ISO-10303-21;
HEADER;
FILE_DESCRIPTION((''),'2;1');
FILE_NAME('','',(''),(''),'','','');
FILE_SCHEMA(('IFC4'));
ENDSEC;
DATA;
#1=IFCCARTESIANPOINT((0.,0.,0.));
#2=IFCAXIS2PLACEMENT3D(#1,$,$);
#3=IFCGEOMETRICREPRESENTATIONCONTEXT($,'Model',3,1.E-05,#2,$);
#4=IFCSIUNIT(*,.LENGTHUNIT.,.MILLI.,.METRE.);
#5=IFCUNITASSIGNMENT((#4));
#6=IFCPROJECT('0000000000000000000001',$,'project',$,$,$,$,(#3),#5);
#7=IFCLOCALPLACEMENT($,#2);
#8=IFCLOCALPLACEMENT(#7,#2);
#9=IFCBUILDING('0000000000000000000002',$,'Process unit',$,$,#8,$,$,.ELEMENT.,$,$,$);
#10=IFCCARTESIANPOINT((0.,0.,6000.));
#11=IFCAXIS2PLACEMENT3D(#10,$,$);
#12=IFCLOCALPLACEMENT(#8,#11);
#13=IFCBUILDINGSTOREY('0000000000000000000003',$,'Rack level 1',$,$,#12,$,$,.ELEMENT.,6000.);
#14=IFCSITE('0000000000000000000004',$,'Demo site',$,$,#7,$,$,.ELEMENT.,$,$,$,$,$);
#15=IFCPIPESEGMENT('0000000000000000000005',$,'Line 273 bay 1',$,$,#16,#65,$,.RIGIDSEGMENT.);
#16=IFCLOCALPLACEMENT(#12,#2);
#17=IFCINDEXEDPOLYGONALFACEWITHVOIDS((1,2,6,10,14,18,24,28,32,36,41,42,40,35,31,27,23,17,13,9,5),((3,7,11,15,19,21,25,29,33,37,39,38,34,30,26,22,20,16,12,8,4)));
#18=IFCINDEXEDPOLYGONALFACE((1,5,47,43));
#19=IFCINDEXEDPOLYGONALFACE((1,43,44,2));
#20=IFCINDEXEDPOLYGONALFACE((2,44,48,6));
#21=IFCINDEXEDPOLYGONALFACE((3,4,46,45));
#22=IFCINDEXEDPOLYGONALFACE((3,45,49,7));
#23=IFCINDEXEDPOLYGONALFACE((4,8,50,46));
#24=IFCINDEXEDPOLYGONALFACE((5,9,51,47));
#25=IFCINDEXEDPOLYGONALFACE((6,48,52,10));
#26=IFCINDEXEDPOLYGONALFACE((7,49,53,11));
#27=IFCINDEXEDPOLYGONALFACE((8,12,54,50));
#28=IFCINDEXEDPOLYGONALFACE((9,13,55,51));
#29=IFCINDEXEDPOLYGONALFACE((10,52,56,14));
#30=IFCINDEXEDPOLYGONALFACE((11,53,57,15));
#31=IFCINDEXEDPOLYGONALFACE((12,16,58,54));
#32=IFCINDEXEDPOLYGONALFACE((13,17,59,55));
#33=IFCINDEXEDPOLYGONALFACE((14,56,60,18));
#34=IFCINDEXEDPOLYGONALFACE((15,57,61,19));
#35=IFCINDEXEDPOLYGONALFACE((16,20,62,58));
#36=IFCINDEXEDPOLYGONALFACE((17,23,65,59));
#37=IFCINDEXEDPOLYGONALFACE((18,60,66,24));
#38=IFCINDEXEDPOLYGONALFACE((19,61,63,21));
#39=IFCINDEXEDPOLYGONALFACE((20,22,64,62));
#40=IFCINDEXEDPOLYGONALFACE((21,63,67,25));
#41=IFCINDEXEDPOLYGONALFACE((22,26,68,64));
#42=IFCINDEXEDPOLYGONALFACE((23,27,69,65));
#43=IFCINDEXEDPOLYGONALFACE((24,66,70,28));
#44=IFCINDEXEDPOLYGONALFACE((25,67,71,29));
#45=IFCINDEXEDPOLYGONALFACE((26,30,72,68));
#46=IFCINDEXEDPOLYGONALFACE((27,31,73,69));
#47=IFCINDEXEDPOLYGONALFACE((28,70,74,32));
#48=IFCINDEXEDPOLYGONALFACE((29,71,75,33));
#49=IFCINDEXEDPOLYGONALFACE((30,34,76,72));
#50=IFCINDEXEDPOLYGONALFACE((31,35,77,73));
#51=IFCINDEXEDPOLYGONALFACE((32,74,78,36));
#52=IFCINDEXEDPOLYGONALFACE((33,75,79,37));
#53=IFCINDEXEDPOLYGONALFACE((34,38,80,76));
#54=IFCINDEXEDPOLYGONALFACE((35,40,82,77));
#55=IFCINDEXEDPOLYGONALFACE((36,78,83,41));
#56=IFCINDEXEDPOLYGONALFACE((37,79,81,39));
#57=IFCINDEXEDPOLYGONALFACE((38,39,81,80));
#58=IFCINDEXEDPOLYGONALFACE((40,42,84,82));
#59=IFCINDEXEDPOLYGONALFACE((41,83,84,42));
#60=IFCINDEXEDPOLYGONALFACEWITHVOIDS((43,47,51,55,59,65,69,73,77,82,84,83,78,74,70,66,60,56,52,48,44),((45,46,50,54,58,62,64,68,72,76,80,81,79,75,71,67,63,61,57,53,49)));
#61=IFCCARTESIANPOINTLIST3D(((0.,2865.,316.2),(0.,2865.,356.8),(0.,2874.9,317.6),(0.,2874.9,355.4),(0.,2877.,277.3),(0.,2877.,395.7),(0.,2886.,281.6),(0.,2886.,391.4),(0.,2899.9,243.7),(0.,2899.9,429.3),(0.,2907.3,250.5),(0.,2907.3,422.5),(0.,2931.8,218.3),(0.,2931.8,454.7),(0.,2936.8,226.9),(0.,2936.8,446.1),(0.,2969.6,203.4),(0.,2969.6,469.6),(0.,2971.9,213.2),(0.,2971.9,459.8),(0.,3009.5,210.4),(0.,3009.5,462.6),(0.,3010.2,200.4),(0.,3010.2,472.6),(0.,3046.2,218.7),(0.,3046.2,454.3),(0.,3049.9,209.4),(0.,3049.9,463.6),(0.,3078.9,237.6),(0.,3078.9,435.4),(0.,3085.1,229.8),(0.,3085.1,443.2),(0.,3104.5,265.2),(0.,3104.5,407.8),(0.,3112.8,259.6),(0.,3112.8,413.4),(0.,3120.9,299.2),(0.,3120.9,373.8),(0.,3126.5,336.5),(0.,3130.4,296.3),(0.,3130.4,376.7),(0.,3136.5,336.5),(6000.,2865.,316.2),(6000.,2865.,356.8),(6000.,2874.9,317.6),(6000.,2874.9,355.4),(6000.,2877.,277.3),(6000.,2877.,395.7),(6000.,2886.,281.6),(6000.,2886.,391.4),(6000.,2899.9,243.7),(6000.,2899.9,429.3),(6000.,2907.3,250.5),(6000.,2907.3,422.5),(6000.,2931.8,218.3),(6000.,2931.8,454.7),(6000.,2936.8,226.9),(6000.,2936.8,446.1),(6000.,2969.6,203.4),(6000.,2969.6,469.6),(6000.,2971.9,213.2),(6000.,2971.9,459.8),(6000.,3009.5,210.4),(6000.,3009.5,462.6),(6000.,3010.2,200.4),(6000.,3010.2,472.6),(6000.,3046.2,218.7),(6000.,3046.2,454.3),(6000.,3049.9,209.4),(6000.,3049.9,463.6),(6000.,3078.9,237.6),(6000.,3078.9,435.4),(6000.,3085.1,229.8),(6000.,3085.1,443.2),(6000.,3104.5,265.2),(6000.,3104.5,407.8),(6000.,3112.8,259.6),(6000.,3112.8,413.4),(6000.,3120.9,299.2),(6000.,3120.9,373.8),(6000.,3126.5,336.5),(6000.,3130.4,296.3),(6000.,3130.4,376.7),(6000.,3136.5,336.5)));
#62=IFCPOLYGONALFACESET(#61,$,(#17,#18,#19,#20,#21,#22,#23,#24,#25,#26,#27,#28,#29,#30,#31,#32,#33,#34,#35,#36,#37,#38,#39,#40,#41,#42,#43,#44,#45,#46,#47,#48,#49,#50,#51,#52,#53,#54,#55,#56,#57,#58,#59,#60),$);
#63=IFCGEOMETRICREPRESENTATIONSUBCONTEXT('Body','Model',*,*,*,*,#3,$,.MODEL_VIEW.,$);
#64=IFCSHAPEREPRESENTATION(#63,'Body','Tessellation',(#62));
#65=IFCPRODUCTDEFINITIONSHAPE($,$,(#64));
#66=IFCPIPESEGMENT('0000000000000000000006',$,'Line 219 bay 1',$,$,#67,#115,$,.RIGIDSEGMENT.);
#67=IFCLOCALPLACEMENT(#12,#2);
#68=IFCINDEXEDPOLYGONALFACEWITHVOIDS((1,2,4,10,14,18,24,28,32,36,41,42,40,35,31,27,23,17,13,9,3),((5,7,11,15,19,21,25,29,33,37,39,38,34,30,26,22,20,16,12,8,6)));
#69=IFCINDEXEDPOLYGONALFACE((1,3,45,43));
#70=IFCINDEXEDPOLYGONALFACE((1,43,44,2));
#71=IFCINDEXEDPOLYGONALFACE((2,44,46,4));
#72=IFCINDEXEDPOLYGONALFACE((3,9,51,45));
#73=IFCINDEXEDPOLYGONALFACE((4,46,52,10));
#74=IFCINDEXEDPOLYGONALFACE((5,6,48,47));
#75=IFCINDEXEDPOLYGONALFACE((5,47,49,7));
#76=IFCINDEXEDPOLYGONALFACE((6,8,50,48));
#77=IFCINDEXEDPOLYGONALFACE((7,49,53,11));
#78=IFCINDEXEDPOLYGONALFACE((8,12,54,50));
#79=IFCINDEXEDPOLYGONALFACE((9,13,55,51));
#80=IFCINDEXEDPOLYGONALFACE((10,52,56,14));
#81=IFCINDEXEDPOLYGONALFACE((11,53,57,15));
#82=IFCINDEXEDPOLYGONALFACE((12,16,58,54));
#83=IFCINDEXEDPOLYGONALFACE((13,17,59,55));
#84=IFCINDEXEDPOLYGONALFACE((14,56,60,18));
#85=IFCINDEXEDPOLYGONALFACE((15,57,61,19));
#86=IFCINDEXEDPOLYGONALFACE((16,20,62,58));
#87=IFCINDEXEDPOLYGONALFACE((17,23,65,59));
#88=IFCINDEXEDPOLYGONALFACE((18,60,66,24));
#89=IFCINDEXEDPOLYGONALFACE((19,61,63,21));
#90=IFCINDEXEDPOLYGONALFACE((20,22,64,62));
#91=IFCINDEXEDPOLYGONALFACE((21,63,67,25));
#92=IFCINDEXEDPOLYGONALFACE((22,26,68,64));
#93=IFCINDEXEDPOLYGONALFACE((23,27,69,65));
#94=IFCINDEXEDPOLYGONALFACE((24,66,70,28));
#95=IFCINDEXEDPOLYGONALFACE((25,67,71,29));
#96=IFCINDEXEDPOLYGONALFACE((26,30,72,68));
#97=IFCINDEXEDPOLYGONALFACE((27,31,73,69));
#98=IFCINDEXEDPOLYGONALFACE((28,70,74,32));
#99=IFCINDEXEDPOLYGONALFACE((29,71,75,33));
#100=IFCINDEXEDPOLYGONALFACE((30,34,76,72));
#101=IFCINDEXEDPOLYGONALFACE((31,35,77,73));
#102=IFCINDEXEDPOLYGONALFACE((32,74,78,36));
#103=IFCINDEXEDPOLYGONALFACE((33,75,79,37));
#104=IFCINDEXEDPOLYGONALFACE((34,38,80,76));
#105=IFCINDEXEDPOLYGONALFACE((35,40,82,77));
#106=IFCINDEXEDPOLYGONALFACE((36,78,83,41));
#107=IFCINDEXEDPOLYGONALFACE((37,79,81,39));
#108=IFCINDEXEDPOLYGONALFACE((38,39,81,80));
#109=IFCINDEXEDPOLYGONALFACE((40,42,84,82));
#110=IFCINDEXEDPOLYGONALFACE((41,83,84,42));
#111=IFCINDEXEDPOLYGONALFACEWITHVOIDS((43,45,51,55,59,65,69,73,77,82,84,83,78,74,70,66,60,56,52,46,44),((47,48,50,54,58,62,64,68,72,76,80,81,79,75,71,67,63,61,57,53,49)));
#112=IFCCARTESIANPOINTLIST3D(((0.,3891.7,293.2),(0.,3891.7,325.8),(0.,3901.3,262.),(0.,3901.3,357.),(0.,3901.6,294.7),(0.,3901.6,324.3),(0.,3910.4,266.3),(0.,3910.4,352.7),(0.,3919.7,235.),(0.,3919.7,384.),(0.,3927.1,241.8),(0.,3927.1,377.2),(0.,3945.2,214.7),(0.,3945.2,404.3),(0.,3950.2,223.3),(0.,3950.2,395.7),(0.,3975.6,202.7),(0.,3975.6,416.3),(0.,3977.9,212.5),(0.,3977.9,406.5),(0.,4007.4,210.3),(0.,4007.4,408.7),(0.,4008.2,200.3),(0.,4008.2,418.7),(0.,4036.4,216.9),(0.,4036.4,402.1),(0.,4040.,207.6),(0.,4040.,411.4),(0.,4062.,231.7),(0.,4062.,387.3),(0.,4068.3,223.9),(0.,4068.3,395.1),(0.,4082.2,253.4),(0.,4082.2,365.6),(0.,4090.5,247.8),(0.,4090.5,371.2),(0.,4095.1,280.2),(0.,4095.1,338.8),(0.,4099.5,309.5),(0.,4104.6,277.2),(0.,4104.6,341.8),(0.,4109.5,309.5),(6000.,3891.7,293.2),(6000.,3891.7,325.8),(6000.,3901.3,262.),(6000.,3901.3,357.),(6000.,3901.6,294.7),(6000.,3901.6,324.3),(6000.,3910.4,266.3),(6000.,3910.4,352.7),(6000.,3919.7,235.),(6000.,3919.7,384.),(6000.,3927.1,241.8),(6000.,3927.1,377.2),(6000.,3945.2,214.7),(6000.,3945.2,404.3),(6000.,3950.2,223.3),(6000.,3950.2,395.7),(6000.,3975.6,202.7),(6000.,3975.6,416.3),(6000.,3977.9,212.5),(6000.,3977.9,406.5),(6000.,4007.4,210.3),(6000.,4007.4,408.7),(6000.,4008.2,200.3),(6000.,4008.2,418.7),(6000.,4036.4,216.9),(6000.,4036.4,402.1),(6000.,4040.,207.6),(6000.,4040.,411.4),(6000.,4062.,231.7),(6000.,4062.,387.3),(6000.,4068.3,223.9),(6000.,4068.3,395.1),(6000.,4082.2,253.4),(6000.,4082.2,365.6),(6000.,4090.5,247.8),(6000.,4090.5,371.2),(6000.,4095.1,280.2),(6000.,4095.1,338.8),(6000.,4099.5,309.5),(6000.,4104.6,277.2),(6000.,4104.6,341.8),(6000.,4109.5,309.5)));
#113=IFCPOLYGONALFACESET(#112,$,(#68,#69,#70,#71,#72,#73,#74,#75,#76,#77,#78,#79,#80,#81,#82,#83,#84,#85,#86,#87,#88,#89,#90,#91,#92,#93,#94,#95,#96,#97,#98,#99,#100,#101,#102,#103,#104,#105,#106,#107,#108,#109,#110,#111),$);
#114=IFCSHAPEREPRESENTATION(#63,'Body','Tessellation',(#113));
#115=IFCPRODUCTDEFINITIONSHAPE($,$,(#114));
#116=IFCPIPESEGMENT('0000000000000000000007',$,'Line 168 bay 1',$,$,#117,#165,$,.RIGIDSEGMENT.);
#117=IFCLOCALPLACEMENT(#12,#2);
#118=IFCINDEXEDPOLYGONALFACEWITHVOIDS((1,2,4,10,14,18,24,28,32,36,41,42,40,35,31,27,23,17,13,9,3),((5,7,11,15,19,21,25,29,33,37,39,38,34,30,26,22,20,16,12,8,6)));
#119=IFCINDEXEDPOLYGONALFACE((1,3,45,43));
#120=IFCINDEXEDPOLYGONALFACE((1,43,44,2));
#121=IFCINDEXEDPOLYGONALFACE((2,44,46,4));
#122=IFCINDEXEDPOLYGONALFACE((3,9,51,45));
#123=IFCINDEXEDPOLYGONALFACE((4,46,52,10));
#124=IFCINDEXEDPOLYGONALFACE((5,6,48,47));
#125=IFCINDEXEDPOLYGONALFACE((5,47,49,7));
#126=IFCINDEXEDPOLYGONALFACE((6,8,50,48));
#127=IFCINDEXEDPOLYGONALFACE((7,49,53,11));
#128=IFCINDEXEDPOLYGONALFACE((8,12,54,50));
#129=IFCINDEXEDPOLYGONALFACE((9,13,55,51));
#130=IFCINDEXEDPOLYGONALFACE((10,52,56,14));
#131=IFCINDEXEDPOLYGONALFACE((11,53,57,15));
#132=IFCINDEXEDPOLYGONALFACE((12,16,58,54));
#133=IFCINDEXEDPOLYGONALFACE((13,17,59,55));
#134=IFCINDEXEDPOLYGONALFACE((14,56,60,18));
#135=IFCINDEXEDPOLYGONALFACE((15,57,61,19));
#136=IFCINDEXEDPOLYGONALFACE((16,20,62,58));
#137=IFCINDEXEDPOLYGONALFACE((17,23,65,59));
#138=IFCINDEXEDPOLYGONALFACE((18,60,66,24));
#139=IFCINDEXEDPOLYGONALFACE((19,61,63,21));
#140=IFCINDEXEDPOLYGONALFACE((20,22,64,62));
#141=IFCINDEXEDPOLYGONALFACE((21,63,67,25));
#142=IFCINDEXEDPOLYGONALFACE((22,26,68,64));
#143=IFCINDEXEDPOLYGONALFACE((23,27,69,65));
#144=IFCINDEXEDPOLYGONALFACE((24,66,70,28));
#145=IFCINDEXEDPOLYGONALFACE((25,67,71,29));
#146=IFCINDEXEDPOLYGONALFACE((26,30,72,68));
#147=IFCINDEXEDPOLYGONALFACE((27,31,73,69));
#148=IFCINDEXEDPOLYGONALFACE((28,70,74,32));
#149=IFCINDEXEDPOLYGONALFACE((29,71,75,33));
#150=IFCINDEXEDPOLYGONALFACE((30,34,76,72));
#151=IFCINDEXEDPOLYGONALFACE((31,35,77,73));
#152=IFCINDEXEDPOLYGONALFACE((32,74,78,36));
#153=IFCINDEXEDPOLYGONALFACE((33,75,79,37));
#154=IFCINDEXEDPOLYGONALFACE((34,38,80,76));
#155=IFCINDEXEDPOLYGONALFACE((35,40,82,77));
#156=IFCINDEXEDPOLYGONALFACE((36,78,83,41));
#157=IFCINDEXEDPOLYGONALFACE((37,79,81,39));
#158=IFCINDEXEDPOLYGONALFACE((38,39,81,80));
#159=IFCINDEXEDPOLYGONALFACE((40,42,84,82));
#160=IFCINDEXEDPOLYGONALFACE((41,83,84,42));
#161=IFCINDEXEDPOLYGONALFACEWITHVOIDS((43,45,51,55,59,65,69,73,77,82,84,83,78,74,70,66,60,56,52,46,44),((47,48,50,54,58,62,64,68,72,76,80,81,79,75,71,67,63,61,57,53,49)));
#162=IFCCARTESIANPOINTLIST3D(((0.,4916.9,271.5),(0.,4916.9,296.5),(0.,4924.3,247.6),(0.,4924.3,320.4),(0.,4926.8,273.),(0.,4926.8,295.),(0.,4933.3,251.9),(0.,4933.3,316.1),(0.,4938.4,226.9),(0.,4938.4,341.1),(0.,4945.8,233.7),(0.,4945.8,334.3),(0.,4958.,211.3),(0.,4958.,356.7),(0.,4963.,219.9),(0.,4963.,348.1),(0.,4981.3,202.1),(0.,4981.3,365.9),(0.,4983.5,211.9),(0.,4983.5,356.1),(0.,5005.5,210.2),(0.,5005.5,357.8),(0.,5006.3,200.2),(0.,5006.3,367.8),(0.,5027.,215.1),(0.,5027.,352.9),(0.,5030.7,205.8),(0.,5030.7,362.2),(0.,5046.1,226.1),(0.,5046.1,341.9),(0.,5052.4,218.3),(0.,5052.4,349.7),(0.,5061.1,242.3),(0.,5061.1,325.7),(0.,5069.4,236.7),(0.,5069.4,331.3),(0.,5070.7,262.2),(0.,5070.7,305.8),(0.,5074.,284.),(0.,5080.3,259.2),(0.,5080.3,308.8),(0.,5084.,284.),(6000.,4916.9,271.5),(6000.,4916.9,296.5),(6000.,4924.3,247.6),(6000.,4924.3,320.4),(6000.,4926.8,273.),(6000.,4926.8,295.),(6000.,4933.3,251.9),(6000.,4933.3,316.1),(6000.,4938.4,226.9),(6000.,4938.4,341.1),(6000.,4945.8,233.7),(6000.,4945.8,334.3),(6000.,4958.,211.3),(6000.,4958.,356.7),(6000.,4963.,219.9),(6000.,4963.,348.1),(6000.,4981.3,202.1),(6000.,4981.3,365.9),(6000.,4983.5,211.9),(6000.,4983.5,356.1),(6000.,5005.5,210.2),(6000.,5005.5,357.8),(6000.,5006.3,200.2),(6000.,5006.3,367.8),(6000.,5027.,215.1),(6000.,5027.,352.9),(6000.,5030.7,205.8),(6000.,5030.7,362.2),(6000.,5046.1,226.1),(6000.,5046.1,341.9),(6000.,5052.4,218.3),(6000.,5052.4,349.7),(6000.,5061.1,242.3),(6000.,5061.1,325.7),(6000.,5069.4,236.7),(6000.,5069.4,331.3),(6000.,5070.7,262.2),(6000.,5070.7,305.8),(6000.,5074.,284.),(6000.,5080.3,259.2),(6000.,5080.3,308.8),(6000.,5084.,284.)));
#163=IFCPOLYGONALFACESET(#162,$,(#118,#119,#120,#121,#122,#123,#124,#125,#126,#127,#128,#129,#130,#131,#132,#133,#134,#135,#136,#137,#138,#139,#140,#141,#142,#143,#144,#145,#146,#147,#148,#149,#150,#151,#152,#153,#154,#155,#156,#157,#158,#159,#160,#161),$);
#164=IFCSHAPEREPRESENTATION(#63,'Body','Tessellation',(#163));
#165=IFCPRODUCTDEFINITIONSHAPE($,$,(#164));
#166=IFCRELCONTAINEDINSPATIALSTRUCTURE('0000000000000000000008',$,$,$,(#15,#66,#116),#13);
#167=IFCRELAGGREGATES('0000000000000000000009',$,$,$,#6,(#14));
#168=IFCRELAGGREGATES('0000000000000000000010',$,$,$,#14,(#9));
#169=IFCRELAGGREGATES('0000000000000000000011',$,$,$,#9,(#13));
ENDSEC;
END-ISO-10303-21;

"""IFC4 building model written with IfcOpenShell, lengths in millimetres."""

from ifc_helpers import new_model, si_unit, frame, origin, place, context, subcontext, project, spatial, hollow_circle, extrude, element, save


model = new_model("IFC4")

# Units and contexts
model_context = context("Model", 3, precision=1e-05, world=origin())
body_context = subcontext(model_context, "Body", "Model", "MODEL_VIEW")
ifc_project = project(units=[si_unit("LENGTHUNIT", "METRE", prefix="MILLI")], contexts=[model_context])

# Site, building, storey
site_placement = place(None, origin())
site = spatial("IfcSite", under=ifc_project, at=site_placement, Name="Demo site", CompositionType="ELEMENT")
building_placement = place(site_placement, origin())
building = spatial("IfcBuilding", under=site, at=building_placement, Name="Process unit", CompositionType="ELEMENT")
storey_placement = place(building_placement, frame((0.0, 0.0, 6000.0)))
storey = spatial("IfcBuildingStorey", under=building, at=storey_placement, Name="Rack level 1", CompositionType="ELEMENT", Elevation=6000.0)

# Pipe segments
pipe_segment_1_placement = place(storey_placement, frame((0.0, 3000.0, 336.5)))
element("IfcPipeSegment", 1, at=pipe_segment_1_placement, inside=storey, Name="Line 273 bay 1", PredefinedType="RIGIDSEGMENT", context=body_context, shape_type="SweptSolid", body=[
    extrude(hollow_circle(Radius=136.5, WallThickness=10.0), frame((0.0, 0.0, 0.0), z_axis=(1.0, 0.0, 0.0), x_axis=(0.0, 1.0, 0.0)), (0.0, 0.0, 1.0), 6000.0),
])
pipe_segment_2_placement = place(storey_placement, frame((0.0, 4000.0, 309.5)))
element("IfcPipeSegment", 2, at=pipe_segment_2_placement, inside=storey, Name="Line 219 bay 1", PredefinedType="RIGIDSEGMENT", context=body_context, shape_type="SweptSolid", body=[
    extrude(hollow_circle(Radius=109.5, WallThickness=10.0), frame((0.0, 0.0, 0.0), z_axis=(1.0, 0.0, 0.0), x_axis=(0.0, 1.0, 0.0)), (0.0, 0.0, 1.0), 6000.0),
])
pipe_segment_3_placement = place(storey_placement, frame((0.0, 5000.0, 284.0)))
element("IfcPipeSegment", 3, at=pipe_segment_3_placement, inside=storey, Name="Line 168 bay 1", PredefinedType="RIGIDSEGMENT", context=body_context, shape_type="SweptSolid", body=[
    extrude(hollow_circle(Radius=84.0, WallThickness=10.0), frame((0.0, 0.0, 0.0), z_axis=(1.0, 0.0, 0.0), x_axis=(0.0, 1.0, 0.0)), (0.0, 0.0, 1.0), 6000.0),
])

save(model, "model.ifc")
